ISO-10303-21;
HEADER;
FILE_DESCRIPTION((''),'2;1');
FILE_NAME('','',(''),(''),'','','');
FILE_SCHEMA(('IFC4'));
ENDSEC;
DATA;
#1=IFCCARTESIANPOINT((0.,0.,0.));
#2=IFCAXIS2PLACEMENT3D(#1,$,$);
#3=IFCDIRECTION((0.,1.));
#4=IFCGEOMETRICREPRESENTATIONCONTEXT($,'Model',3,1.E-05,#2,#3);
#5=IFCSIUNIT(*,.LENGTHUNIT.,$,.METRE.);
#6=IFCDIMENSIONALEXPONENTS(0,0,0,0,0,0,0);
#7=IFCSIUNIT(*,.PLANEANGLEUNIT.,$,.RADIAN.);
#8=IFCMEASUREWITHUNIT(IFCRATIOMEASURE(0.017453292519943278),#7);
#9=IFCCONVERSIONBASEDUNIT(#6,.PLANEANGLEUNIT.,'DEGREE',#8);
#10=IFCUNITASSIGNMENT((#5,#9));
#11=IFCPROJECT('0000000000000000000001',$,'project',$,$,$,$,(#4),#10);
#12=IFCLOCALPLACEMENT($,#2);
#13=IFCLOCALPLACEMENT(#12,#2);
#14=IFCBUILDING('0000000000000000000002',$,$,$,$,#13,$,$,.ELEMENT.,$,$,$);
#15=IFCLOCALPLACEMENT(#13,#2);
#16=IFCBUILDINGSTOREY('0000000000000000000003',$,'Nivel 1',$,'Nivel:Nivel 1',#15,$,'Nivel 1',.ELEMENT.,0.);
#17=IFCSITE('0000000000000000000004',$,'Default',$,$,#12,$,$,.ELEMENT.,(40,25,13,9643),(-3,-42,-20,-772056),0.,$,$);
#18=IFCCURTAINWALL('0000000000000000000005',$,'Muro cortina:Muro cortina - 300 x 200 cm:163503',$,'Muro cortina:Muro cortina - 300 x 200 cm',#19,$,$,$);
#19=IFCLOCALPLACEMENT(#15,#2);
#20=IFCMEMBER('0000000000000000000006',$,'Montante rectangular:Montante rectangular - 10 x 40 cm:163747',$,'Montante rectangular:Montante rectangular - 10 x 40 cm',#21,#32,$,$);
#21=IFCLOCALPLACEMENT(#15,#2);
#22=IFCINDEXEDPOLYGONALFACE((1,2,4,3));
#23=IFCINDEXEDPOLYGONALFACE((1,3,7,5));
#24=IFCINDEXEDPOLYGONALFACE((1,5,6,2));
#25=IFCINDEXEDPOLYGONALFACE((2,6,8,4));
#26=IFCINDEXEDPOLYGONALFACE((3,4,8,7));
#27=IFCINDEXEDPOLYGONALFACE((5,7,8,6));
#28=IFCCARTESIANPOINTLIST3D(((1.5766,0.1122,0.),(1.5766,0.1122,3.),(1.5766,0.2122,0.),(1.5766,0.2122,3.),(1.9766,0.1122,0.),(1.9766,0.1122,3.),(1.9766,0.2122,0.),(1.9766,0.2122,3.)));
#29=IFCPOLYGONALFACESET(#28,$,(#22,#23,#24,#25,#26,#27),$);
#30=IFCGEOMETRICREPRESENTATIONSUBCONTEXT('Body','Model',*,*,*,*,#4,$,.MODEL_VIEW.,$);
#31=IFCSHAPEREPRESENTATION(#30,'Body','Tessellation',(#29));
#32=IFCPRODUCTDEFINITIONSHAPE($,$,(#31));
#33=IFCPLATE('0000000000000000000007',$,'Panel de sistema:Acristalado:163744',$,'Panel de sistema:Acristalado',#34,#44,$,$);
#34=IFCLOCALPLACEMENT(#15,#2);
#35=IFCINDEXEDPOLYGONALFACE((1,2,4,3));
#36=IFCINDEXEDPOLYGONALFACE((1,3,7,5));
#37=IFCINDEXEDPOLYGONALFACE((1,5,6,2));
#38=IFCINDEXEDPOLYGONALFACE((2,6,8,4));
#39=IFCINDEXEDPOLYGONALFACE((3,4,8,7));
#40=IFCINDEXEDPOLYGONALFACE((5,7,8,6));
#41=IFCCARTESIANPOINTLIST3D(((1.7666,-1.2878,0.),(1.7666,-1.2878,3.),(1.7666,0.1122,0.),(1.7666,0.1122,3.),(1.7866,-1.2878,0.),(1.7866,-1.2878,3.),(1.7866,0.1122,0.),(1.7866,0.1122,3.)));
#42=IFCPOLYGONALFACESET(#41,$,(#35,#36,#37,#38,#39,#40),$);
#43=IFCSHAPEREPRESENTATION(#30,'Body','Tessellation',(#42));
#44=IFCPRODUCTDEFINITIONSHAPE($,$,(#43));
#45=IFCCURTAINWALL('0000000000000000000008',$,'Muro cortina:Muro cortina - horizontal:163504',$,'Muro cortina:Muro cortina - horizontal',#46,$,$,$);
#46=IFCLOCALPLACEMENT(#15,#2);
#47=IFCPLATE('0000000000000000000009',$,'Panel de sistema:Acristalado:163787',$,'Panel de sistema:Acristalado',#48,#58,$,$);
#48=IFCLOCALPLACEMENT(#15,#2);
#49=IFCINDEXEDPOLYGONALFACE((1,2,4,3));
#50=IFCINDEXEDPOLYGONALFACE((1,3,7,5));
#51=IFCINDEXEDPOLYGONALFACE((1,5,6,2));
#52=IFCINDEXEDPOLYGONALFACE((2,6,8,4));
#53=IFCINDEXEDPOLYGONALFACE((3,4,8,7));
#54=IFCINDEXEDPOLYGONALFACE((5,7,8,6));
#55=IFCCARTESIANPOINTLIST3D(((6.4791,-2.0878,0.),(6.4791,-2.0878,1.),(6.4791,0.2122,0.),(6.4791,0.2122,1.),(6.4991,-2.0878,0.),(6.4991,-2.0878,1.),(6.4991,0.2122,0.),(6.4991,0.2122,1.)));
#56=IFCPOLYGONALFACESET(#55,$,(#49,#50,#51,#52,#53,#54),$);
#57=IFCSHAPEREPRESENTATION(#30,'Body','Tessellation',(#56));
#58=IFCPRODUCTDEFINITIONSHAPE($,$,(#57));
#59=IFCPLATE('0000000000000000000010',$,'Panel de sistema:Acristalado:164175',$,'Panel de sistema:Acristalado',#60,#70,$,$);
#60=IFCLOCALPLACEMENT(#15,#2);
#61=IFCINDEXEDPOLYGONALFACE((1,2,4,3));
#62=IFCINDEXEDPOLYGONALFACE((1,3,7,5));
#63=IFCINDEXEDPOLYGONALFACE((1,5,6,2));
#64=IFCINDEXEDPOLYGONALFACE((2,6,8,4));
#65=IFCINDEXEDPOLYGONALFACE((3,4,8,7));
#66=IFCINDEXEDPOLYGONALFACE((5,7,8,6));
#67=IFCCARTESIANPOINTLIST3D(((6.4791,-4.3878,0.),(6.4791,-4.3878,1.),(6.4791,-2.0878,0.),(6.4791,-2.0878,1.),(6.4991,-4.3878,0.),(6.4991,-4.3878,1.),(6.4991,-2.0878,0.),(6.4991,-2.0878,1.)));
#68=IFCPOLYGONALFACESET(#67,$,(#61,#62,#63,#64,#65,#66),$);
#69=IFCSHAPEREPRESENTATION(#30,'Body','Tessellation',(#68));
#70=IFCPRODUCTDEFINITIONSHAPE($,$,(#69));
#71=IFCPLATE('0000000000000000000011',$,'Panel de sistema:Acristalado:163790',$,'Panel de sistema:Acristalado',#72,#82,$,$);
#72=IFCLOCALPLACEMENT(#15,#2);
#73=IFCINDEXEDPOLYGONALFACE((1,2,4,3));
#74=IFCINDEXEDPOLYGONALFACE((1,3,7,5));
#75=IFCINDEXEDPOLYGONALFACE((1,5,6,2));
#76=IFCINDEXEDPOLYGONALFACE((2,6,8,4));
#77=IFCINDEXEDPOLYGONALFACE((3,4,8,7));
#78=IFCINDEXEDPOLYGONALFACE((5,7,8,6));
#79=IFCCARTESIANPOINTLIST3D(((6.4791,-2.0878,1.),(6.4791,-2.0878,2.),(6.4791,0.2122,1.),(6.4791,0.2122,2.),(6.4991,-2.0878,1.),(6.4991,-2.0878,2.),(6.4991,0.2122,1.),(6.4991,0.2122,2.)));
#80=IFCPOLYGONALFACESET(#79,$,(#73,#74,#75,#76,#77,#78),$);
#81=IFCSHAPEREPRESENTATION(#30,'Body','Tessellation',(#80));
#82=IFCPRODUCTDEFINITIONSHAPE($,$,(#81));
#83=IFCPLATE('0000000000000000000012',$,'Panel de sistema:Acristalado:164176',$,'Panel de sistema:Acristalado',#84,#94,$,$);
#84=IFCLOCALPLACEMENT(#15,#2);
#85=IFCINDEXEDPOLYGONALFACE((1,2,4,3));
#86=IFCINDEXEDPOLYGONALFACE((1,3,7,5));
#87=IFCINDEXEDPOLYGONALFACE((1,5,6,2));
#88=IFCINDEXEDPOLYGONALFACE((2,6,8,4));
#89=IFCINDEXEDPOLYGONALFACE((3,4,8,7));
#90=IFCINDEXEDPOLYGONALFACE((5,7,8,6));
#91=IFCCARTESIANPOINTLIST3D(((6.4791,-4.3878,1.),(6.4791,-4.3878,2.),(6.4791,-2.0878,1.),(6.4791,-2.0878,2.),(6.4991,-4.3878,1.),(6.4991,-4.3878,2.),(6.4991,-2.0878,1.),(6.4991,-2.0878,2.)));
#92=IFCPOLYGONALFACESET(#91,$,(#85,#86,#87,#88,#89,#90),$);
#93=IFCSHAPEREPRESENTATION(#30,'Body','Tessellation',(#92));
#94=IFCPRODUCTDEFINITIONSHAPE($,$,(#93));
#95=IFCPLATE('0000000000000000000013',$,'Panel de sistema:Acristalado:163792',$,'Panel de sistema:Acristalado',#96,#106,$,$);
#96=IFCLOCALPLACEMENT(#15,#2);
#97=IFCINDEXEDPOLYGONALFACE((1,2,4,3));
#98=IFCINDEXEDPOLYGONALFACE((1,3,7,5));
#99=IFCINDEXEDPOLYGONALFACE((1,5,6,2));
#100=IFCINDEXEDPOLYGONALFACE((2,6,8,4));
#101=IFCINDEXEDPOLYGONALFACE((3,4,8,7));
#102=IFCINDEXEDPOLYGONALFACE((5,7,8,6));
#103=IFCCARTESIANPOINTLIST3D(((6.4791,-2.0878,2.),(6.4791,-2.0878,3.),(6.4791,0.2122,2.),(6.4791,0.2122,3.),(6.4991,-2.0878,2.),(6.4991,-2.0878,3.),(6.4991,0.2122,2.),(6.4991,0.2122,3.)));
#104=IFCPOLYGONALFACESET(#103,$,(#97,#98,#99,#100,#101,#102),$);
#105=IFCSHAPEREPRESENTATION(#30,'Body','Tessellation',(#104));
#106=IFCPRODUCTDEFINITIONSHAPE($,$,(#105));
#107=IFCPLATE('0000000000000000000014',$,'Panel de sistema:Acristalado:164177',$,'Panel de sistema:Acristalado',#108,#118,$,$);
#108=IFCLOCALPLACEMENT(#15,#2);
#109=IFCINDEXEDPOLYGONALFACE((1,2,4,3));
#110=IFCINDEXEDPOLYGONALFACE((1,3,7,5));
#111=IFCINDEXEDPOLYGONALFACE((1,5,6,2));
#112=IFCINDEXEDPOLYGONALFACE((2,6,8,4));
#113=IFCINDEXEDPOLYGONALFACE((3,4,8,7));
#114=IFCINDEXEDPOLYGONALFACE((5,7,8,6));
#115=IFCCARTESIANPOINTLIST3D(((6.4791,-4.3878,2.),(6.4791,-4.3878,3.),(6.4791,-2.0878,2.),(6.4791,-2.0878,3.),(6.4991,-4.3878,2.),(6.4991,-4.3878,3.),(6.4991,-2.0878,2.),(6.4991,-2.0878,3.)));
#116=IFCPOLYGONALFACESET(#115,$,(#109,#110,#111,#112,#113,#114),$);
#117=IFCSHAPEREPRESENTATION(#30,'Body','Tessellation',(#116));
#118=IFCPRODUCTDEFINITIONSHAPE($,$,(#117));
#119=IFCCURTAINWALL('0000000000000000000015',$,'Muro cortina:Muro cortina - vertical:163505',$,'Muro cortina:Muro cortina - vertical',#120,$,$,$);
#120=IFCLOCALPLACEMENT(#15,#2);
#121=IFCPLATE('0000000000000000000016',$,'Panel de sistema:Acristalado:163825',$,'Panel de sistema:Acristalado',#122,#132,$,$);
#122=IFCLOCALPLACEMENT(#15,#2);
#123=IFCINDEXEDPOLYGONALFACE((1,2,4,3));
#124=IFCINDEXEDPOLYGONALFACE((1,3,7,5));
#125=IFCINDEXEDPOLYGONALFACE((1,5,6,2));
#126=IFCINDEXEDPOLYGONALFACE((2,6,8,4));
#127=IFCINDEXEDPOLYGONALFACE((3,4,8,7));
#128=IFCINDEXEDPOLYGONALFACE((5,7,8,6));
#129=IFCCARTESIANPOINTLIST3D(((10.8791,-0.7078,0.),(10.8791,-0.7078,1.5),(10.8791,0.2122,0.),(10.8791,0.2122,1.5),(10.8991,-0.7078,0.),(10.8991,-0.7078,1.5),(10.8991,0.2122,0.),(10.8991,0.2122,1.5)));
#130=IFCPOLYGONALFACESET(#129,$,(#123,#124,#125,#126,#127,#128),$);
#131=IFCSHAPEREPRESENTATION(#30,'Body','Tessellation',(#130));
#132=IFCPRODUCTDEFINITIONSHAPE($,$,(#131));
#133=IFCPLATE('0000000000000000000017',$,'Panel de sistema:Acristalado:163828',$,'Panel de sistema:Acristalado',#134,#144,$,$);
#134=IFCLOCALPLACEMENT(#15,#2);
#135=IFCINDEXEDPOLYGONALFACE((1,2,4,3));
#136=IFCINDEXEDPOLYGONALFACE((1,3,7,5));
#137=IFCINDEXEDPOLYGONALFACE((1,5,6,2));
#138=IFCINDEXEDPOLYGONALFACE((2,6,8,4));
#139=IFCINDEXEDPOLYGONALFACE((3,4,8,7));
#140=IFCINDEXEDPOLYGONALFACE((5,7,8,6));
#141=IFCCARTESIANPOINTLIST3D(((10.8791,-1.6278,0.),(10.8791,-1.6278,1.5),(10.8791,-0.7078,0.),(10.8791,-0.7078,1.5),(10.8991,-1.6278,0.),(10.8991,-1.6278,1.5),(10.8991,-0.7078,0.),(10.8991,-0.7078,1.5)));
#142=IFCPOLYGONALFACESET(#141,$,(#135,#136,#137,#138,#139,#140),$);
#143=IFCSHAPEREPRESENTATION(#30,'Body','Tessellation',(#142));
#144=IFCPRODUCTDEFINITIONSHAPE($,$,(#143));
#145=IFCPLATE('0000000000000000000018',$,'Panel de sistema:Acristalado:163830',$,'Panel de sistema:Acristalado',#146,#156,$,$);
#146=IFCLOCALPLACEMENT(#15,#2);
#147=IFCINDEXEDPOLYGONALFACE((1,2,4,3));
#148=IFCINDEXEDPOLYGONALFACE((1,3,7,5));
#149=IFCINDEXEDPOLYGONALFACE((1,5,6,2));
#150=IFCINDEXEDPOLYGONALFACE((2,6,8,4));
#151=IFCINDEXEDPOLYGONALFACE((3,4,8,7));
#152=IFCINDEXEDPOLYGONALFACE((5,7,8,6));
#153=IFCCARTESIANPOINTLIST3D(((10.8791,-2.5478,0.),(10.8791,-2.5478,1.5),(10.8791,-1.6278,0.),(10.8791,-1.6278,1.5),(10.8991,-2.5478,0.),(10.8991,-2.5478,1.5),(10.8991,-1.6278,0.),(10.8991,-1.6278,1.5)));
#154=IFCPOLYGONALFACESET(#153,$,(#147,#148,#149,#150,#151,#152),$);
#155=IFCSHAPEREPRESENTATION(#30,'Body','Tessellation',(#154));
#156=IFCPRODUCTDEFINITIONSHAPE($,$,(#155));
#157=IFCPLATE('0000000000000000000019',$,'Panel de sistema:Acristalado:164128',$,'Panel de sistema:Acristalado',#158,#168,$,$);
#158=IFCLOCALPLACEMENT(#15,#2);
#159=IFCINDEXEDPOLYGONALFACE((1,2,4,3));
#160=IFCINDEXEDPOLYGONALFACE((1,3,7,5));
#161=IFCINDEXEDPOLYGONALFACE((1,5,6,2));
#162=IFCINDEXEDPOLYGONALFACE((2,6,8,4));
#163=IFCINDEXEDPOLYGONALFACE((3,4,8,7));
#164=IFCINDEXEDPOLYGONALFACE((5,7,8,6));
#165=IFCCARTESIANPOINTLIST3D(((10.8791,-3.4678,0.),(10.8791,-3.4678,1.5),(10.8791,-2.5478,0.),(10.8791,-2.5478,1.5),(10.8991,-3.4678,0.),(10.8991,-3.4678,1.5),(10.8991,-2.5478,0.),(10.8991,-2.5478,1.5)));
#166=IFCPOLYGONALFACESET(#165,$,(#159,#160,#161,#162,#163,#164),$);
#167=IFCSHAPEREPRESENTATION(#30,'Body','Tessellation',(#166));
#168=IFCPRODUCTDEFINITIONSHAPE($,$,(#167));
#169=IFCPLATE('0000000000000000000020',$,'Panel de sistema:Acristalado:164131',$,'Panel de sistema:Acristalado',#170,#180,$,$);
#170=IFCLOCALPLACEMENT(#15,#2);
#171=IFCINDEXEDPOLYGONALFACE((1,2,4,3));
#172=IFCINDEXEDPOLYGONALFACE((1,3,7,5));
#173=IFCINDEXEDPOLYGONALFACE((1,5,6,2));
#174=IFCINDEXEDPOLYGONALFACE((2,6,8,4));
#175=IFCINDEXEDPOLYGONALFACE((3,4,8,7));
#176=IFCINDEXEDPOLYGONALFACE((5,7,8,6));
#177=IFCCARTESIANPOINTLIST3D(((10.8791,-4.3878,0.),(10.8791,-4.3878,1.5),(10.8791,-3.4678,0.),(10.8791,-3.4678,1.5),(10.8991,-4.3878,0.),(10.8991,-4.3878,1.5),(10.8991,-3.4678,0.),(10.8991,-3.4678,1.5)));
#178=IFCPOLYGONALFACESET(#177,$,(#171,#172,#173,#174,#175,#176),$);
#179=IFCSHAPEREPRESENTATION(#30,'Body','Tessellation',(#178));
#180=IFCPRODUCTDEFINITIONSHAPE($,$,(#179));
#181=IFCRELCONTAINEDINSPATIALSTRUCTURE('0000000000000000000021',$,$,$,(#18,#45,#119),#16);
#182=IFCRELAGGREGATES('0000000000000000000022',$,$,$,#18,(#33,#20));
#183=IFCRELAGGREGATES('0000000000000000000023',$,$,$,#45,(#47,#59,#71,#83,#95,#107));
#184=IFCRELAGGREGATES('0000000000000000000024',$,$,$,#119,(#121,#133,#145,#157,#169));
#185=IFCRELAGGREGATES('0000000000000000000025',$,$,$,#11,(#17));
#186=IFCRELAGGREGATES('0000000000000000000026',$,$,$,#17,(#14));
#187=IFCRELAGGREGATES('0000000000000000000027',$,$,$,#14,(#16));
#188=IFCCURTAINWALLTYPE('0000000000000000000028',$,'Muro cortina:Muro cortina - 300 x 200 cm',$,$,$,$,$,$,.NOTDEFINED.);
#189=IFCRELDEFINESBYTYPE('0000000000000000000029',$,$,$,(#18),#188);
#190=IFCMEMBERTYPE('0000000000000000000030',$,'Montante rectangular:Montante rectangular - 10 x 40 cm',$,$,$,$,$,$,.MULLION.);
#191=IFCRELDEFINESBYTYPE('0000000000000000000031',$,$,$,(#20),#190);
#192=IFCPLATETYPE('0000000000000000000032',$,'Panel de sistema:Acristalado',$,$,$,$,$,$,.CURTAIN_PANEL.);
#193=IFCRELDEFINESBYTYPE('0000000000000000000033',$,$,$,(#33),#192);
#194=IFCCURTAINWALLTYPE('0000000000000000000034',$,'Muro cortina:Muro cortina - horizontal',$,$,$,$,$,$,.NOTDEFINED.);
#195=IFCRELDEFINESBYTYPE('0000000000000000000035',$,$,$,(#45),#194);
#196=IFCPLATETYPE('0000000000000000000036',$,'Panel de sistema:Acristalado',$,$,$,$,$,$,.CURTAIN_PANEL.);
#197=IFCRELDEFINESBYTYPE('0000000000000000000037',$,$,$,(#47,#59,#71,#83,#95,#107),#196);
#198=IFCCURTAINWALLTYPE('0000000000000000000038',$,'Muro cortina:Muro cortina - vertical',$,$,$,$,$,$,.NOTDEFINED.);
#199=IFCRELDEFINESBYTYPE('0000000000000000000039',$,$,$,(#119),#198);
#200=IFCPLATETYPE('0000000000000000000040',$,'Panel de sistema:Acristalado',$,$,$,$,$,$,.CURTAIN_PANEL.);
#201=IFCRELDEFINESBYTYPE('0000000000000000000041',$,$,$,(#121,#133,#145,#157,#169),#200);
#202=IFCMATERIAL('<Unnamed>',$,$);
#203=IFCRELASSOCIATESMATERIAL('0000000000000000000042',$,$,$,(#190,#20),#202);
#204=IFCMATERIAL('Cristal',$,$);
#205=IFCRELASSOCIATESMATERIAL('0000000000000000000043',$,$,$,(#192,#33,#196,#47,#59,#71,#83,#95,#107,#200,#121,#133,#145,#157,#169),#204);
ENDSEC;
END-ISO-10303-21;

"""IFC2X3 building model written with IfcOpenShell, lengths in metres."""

from ifc_helpers import new_model, entity, si_unit, converted_unit, direction, frame, origin, origin_2d_with_axis, place, context, subcontext, project, spatial, rectangle, extrude, source, transform, mapped, material, type_object, type_shapes, element, aggregate, save


model = new_model("IFC2X3")

# Units and contexts
model_context = context("Model", 3, precision=1e-05, world=origin(), true_north=direction((0.0, 1.0)))
body_context = subcontext(model_context, "Body", "Model", "MODEL_VIEW")
ifc_project = project(units=[si_unit("LENGTHUNIT", "METRE"), converted_unit("PLANEANGLEUNIT", "DEGREE", entity("IfcRatioMeasure", 0.017453292519943278), si_unit("PLANEANGLEUNIT", "RADIAN"), dimensions=[0, 0, 0, 0, 0, 0, 0])], contexts=[model_context])

# Site, building, storey
site_placement = place(None, origin())
site = spatial("IfcSite", under=ifc_project, at=site_placement, Name="Default", CompositionType="ELEMENT", RefLatitude=(40, 25, 13, 9643), RefLongitude=(-3, -42, -20, -772056), RefElevation=0.0)
building_placement = place(site_placement, origin())
building = spatial("IfcBuilding", under=site, at=building_placement, CompositionType="ELEMENT")
storey_placement = place(building_placement, origin())
storey = spatial("IfcBuildingStorey", under=building, at=storey_placement, Name="Nivel 1", ObjectType="Nivel:Nivel 1", LongName="Nivel 1", CompositionType="ELEMENT", Elevation=0.0)

# Curtain wall, member, plate
curtain_wall_type_1 = type_object("IfcCurtainWallType", Name="Muro cortina:Muro cortina - 300 x 200 cm", PredefinedType="NOTDEFINED")
curtain_wall_1_placement = place(storey_placement, origin())
curtain_wall_1 = element("IfcCurtainWall", 1, at=curtain_wall_1_placement, inside=storey, type_object=curtain_wall_type_1, Name="Muro cortina:Muro cortina - 300 x 200 cm:163503", ObjectType="Muro cortina:Muro cortina - 300 x 200 cm")
ifc_material_1 = material(Name="<Unnamed>")
member_type = type_object("IfcMemberType", Name="Montante rectangular:Montante rectangular - 10 x 40 cm", PredefinedType="MULLION", material=ifc_material_1)
shared_shape_1 = source(origin(), body_context, "Body", "SweptSolid", [
    extrude(rectangle(XDim=0.4, YDim=0.1, at=origin_2d_with_axis()), frame((-0.05, 0.0, -3.0), z_axis=(0.0, 0.0, 1.0), x_axis=(0.0, -1.0, 0.0)), (0.0, 0.0, 1.0), 3.0),
])
type_shapes(member_type, [shared_shape_1])
member_placement = place(curtain_wall_1_placement, frame((1.7766, 0.2122, 3.0), z_axis=(0.0, 0.0, 1.0), x_axis=(0.0, 1.0, 0.0)))
member = element("IfcMember", 2, at=member_placement, type_object=member_type, material=ifc_material_1, Name="Montante rectangular:Montante rectangular - 10 x 40 cm:163747", ObjectType="Montante rectangular:Montante rectangular - 10 x 40 cm", context=body_context, shape_type="MappedRepresentation", body=[
    mapped(shared_shape_1, transform((0.0, 0.0, 0.0), scale=1.0)),
])
ifc_material_2 = material(Name="Cristal")
plate_type_1 = type_object("IfcPlateType", Name="Panel de sistema:Acristalado", PredefinedType="CURTAIN_PANEL", material=ifc_material_2)
shared_shape_2 = source(origin(), body_context, "Body", "SweptSolid", [
    extrude(rectangle(XDim=0.02, YDim=1.4, at=origin_2d_with_axis()), frame((0.0, 0.0, 0.0), z_axis=(0.0, 0.0, 1.0), x_axis=(0.0, 1.0, 0.0)), (0.0, 0.0, 1.0), 3.0),
])
type_shapes(plate_type_1, [shared_shape_2])
plate_1_placement = place(curtain_wall_1_placement, frame((1.7766, -0.5878, 0.0), z_axis=(0.0, 0.0, 1.0), x_axis=(0.0, -1.0, 0.0)))
plate_1 = element("IfcPlate", 3, at=plate_1_placement, type_object=plate_type_1, material=ifc_material_2, Name="Panel de sistema:Acristalado:163744", ObjectType="Panel de sistema:Acristalado", context=body_context, shape_type="MappedRepresentation", body=[
    mapped(shared_shape_2, transform((0.0, 0.0, 0.0), scale=1.0)),
])
aggregate(curtain_wall_1, [plate_1, member])

# Curtain walls, plates
curtain_wall_type_2 = type_object("IfcCurtainWallType", Name="Muro cortina:Muro cortina - horizontal", PredefinedType="NOTDEFINED")
curtain_wall_2_placement = place(storey_placement, origin())
curtain_wall_2 = element("IfcCurtainWall", 4, at=curtain_wall_2_placement, inside=storey, type_object=curtain_wall_type_2, Name="Muro cortina:Muro cortina - horizontal:163504", ObjectType="Muro cortina:Muro cortina - horizontal")
plate_type_2 = type_object("IfcPlateType", Name="Panel de sistema:Acristalado", PredefinedType="CURTAIN_PANEL", material=ifc_material_2)
shared_shape_3 = source(origin(), body_context, "Body", "SweptSolid", [
    extrude(rectangle(XDim=0.02, YDim=2.3, at=origin_2d_with_axis()), frame((0.0, 0.0, 0.0), z_axis=(0.0, 0.0, 1.0), x_axis=(0.0, 1.0, 0.0)), (0.0, 0.0, 1.0), 1.0),
])
type_shapes(plate_type_2, [shared_shape_3])
plate_2_placement = place(curtain_wall_2_placement, frame((6.4891, -0.9378, 0.0), z_axis=(0.0, 0.0, 1.0), x_axis=(0.0, -1.0, 0.0)))
plate_2 = element("IfcPlate", 5, at=plate_2_placement, type_object=plate_type_2, material=ifc_material_2, Name="Panel de sistema:Acristalado:163787", ObjectType="Panel de sistema:Acristalado", context=body_context, shape_type="MappedRepresentation", body=[
    mapped(shared_shape_3, transform((0.0, 0.0, 0.0), scale=1.0)),
])
plate_3_placement = place(curtain_wall_2_placement, frame((6.4891, -3.2378, 0.0), z_axis=(0.0, 0.0, 1.0), x_axis=(0.0, -1.0, 0.0)))
plate_3 = element("IfcPlate", 6, at=plate_3_placement, type_object=plate_type_2, material=ifc_material_2, Name="Panel de sistema:Acristalado:164175", ObjectType="Panel de sistema:Acristalado", context=body_context, shape_type="MappedRepresentation", body=[
    mapped(shared_shape_3, transform((0.0, 0.0, 0.0), scale=1.0)),
])
plate_4_placement = place(curtain_wall_2_placement, frame((6.4891, -0.9378, 1.0), z_axis=(0.0, 0.0, 1.0), x_axis=(0.0, -1.0, 0.0)))
plate_4 = element("IfcPlate", 7, at=plate_4_placement, type_object=plate_type_2, material=ifc_material_2, Name="Panel de sistema:Acristalado:163790", ObjectType="Panel de sistema:Acristalado", context=body_context, shape_type="MappedRepresentation", body=[
    mapped(shared_shape_3, transform((0.0, 0.0, 0.0), scale=1.0)),
])
plate_5_placement = place(curtain_wall_2_placement, frame((6.4891, -3.2378, 1.0), z_axis=(0.0, 0.0, 1.0), x_axis=(0.0, -1.0, 0.0)))
plate_5 = element("IfcPlate", 8, at=plate_5_placement, type_object=plate_type_2, material=ifc_material_2, Name="Panel de sistema:Acristalado:164176", ObjectType="Panel de sistema:Acristalado", context=body_context, shape_type="MappedRepresentation", body=[
    mapped(shared_shape_3, transform((0.0, 0.0, 0.0), scale=1.0)),
])
plate_6_placement = place(curtain_wall_2_placement, frame((6.4891, -0.9378, 2.0), z_axis=(0.0, 0.0, 1.0), x_axis=(0.0, -1.0, 0.0)))
plate_6 = element("IfcPlate", 9, at=plate_6_placement, type_object=plate_type_2, material=ifc_material_2, Name="Panel de sistema:Acristalado:163792", ObjectType="Panel de sistema:Acristalado", context=body_context, shape_type="MappedRepresentation", body=[
    mapped(shared_shape_3, transform((0.0, 0.0, 0.0), scale=1.0)),
])
plate_7_placement = place(curtain_wall_2_placement, frame((6.4891, -3.2378, 2.0), z_axis=(0.0, 0.0, 1.0), x_axis=(0.0, -1.0, 0.0)))
plate_7 = element("IfcPlate", 10, at=plate_7_placement, type_object=plate_type_2, material=ifc_material_2, Name="Panel de sistema:Acristalado:164177", ObjectType="Panel de sistema:Acristalado", context=body_context, shape_type="MappedRepresentation", body=[
    mapped(shared_shape_3, transform((0.0, 0.0, 0.0), scale=1.0)),
])
aggregate(curtain_wall_2, [plate_2, plate_3, plate_4, plate_5, plate_6, plate_7])
curtain_wall_type_3 = type_object("IfcCurtainWallType", Name="Muro cortina:Muro cortina - vertical", PredefinedType="NOTDEFINED")
curtain_wall_3_placement = place(storey_placement, origin())
curtain_wall_3 = element("IfcCurtainWall", 11, at=curtain_wall_3_placement, inside=storey, type_object=curtain_wall_type_3, Name="Muro cortina:Muro cortina - vertical:163505", ObjectType="Muro cortina:Muro cortina - vertical")
plate_type_3 = type_object("IfcPlateType", Name="Panel de sistema:Acristalado", PredefinedType="CURTAIN_PANEL", material=ifc_material_2)
shared_shape_4 = source(origin(), body_context, "Body", "SweptSolid", [
    extrude(rectangle(XDim=0.02, YDim=0.92, at=origin_2d_with_axis()), frame((0.0, 0.0, 0.0), z_axis=(0.0, 0.0, 1.0), x_axis=(0.0, 1.0, 0.0)), (0.0, 0.0, 1.0), 1.5),
])
type_shapes(plate_type_3, [shared_shape_4])
plate_8_placement = place(curtain_wall_3_placement, frame((10.8891, -0.2478, 0.0), z_axis=(0.0, 0.0, 1.0), x_axis=(0.0, -1.0, 0.0)))
plate_8 = element("IfcPlate", 12, at=plate_8_placement, type_object=plate_type_3, material=ifc_material_2, Name="Panel de sistema:Acristalado:163825", ObjectType="Panel de sistema:Acristalado", context=body_context, shape_type="MappedRepresentation", body=[
    mapped(shared_shape_4, transform((0.0, 0.0, 0.0), scale=1.0)),
])
plate_9_placement = place(curtain_wall_3_placement, frame((10.8891, -1.1678, 0.0), z_axis=(0.0, 0.0, 1.0), x_axis=(0.0, -1.0, 0.0)))
plate_9 = element("IfcPlate", 13, at=plate_9_placement, type_object=plate_type_3, material=ifc_material_2, Name="Panel de sistema:Acristalado:163828", ObjectType="Panel de sistema:Acristalado", context=body_context, shape_type="MappedRepresentation", body=[
    mapped(shared_shape_4, transform((0.0, 0.0, 0.0), scale=1.0)),
])
plate_10_placement = place(curtain_wall_3_placement, frame((10.8891, -2.0878, 0.0), z_axis=(0.0, 0.0, 1.0), x_axis=(0.0, -1.0, 0.0)))
plate_10 = element("IfcPlate", 14, at=plate_10_placement, type_object=plate_type_3, material=ifc_material_2, Name="Panel de sistema:Acristalado:163830", ObjectType="Panel de sistema:Acristalado", context=body_context, shape_type="MappedRepresentation", body=[
    mapped(shared_shape_4, transform((0.0, 0.0, 0.0), scale=1.0)),
])
plate_11_placement = place(curtain_wall_3_placement, frame((10.8891, -3.0078, 0.0), z_axis=(0.0, 0.0, 1.0), x_axis=(0.0, -1.0, 0.0)))
plate_11 = element("IfcPlate", 15, at=plate_11_placement, type_object=plate_type_3, material=ifc_material_2, Name="Panel de sistema:Acristalado:164128", ObjectType="Panel de sistema:Acristalado", context=body_context, shape_type="MappedRepresentation", body=[
    mapped(shared_shape_4, transform((0.0, 0.0, 0.0), scale=1.0)),
])
plate_12_placement = place(curtain_wall_3_placement, frame((10.8891, -3.9278, 0.0), z_axis=(0.0, 0.0, 1.0), x_axis=(0.0, -1.0, 0.0)))
plate_12 = element("IfcPlate", 16, at=plate_12_placement, type_object=plate_type_3, material=ifc_material_2, Name="Panel de sistema:Acristalado:164131", ObjectType="Panel de sistema:Acristalado", context=body_context, shape_type="MappedRepresentation", body=[
    mapped(shared_shape_4, transform((0.0, 0.0, 0.0), scale=1.0)),
])
aggregate(curtain_wall_3, [plate_8, plate_9, plate_10, plate_11, plate_12])

save(model, "model.ifc")
